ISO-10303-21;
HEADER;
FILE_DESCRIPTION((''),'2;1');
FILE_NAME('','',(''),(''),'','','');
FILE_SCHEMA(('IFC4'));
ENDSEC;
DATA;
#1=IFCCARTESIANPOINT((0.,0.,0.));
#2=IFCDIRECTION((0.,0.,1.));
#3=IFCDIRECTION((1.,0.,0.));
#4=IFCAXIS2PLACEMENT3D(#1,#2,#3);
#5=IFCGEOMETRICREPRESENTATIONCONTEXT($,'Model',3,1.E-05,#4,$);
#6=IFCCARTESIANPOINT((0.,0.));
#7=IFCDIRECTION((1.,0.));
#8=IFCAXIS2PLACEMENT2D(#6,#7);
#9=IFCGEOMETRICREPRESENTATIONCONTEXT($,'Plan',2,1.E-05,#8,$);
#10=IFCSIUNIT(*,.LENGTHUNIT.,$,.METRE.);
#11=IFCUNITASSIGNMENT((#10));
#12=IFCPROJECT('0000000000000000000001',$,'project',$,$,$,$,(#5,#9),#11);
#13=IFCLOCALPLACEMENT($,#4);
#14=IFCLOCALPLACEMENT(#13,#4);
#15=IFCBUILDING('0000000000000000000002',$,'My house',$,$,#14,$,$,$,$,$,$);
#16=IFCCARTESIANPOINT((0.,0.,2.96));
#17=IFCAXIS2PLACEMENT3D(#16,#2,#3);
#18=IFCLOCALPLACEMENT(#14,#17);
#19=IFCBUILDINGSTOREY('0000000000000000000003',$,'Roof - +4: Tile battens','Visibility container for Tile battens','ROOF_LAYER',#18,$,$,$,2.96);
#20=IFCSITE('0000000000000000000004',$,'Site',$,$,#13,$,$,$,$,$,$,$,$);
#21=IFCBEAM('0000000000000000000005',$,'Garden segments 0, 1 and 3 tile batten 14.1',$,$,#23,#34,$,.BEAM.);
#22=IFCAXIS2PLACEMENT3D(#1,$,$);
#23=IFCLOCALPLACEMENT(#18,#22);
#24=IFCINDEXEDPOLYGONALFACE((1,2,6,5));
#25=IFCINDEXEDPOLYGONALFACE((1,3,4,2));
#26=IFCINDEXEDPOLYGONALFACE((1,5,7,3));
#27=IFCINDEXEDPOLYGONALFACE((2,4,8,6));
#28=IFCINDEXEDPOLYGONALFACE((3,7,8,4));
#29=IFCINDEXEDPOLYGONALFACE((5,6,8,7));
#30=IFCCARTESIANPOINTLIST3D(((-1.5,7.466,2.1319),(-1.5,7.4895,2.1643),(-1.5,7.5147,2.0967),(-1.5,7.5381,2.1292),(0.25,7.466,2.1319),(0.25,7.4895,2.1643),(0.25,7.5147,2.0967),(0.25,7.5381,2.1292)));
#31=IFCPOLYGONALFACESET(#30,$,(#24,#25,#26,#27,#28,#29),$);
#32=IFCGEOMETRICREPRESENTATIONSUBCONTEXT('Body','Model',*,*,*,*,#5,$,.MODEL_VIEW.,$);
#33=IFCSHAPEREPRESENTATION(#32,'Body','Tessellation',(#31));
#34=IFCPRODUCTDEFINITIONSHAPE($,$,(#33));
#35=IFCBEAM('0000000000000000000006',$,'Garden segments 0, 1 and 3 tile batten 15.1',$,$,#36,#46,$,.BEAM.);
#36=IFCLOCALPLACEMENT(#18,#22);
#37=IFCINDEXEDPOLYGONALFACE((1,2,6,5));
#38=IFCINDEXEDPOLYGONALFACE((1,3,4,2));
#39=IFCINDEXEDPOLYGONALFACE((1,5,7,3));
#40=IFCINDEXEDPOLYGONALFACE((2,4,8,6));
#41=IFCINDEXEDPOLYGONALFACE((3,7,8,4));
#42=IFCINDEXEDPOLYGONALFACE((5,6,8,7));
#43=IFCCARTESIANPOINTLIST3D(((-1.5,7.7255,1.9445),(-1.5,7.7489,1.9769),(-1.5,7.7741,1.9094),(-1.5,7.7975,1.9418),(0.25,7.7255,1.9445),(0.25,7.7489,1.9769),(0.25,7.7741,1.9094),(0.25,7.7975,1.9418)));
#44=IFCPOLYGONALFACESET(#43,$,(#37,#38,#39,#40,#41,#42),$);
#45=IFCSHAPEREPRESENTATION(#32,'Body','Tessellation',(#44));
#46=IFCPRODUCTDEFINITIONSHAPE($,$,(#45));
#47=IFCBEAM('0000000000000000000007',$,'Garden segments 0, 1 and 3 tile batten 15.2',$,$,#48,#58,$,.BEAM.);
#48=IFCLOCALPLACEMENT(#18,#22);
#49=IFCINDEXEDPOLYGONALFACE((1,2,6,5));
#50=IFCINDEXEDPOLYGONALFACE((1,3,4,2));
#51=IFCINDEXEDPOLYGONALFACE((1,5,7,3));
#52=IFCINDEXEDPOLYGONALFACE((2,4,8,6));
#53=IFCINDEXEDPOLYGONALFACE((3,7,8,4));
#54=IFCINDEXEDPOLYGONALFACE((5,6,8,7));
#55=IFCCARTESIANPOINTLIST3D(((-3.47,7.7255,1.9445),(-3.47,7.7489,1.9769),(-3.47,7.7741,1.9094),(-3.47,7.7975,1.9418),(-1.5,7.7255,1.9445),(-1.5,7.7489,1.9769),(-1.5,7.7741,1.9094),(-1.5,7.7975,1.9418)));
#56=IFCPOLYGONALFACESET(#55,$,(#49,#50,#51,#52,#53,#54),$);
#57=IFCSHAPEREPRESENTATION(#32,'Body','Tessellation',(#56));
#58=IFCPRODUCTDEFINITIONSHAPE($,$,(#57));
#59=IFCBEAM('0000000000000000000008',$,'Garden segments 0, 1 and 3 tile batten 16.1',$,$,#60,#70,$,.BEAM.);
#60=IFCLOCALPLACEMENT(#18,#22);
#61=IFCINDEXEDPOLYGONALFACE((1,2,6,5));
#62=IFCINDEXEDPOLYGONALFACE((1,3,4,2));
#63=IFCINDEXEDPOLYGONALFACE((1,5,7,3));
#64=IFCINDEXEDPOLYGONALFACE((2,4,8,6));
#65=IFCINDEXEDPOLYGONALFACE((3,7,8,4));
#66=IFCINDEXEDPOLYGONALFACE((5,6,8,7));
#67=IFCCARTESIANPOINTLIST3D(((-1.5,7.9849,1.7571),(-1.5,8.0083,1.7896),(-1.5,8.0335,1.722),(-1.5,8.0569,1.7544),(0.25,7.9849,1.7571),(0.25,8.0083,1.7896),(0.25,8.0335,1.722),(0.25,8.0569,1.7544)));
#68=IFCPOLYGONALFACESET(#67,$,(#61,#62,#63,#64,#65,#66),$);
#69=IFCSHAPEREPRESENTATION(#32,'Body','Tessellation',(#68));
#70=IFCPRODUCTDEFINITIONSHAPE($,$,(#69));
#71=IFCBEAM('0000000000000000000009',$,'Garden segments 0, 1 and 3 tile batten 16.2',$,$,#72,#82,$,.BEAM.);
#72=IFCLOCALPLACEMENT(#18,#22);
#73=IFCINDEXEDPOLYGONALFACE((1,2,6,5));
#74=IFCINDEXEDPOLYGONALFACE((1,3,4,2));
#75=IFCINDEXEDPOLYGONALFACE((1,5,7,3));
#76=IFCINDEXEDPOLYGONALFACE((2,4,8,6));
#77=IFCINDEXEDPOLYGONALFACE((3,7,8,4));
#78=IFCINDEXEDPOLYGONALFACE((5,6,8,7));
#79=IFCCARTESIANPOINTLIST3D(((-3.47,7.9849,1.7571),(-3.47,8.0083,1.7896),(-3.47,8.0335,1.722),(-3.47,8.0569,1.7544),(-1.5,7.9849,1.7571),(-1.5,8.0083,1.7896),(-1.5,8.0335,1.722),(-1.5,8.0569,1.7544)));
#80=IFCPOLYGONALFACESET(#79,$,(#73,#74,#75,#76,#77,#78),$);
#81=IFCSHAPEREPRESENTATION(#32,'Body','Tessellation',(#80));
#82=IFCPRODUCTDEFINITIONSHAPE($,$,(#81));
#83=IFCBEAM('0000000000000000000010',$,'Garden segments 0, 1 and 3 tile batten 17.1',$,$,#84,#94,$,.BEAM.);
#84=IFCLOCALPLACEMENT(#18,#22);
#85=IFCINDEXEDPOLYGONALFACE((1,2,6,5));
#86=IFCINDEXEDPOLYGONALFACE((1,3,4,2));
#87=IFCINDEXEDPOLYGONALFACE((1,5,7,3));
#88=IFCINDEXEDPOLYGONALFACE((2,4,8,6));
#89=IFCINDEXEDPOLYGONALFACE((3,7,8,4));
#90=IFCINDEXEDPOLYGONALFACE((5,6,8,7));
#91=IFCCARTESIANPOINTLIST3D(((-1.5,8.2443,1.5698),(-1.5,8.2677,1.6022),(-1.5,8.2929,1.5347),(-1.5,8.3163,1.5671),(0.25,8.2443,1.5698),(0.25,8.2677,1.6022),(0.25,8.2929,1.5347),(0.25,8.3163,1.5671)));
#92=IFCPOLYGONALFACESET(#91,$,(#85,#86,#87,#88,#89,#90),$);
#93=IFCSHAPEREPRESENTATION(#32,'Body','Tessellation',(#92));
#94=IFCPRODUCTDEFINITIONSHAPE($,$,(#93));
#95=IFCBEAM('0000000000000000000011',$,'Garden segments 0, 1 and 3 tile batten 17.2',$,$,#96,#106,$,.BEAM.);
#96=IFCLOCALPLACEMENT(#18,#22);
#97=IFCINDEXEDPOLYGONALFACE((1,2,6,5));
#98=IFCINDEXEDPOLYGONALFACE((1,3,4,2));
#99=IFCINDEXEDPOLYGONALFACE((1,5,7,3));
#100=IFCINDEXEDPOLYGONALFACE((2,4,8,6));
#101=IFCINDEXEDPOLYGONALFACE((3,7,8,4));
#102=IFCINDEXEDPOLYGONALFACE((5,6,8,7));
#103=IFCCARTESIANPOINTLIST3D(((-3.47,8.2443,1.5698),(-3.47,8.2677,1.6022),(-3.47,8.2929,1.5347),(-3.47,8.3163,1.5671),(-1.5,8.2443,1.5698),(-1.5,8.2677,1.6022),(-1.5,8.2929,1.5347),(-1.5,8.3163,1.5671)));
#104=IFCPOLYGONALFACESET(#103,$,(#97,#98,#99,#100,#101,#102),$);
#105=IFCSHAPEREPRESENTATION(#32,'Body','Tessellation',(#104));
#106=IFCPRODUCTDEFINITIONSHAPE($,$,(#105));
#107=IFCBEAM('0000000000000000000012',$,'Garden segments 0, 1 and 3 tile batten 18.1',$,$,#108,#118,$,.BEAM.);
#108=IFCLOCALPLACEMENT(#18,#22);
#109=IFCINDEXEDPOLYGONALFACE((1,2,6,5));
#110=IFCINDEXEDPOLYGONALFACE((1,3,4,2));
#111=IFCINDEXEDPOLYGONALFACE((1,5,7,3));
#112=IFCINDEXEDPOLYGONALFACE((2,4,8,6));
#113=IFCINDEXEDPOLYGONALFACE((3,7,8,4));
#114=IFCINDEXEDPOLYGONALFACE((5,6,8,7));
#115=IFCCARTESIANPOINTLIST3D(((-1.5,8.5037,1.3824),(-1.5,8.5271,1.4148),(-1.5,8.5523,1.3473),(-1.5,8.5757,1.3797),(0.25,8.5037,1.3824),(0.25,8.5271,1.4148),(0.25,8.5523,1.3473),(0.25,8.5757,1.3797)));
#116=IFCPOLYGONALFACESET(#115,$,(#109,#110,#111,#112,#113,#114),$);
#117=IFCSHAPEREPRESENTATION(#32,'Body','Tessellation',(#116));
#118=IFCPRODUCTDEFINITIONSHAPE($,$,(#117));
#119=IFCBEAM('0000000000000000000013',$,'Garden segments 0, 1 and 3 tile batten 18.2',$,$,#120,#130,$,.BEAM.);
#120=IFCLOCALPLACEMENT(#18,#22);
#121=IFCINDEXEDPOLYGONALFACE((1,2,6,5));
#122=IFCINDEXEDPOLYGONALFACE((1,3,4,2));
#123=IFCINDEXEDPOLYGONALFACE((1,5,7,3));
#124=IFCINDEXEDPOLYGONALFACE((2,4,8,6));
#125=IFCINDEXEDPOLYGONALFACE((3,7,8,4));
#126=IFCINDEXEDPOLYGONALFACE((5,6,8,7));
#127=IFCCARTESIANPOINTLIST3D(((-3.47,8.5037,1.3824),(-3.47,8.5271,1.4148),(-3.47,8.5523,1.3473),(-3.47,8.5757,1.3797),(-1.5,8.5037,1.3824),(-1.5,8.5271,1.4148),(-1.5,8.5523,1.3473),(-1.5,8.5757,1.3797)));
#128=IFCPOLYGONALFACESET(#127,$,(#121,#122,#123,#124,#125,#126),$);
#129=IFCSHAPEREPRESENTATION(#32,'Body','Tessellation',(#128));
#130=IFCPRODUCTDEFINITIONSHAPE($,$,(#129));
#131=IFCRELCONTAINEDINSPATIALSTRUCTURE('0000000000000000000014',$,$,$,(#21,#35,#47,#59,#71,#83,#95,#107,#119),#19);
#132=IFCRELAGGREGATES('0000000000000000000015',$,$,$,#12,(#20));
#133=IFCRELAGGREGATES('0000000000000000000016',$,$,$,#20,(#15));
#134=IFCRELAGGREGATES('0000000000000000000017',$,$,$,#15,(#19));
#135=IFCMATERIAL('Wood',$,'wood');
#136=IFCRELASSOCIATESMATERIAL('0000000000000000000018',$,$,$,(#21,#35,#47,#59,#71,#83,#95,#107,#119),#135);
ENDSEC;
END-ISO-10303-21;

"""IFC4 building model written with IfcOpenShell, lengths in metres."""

from ifc_helpers import new_model, si_unit, frame, origin_with_axes, origin_2d_with_axis, place, context, subcontext, project, spatial, rectangle, extrude, clip, halfspace, source, transform, mapped, material, element, save


model = new_model("IFC4")

# Units and contexts
model_context = context("Model", 3, precision=1e-05, world=origin_with_axes())
plan_context = context("Plan", 2, precision=1e-05, world=origin_2d_with_axis())
body_context = subcontext(model_context, "Body", "Model", "MODEL_VIEW")
ifc_project = project(units=[si_unit("LENGTHUNIT", "METRE")], contexts=[model_context, plan_context])

# Site, building, storey
site_placement = place(None, origin_with_axes())
site = spatial("IfcSite", under=ifc_project, at=site_placement, Name="Site")
building_placement = place(site_placement, origin_with_axes())
building = spatial("IfcBuilding", under=site, at=building_placement, Name="My house")
storey_placement = place(building_placement, frame((0.0, 0.0, 2.96), z_axis=(0.0, 0.0, 1.0), x_axis=(1.0, 0.0, 0.0)))
storey = spatial("IfcBuildingStorey", under=building, at=storey_placement, Name="Roof - +4: Tile battens", Description="Visibility container for Tile battens", ObjectType="ROOF_LAYER", Elevation=2.96)

# Shared definitions
ifc_material = material(Name="Wood", Category="wood")

# Beam
shared_shape_1 = source(origin_with_axes(), body_context, "Body", "Clipping", [
    clip(clip(extrude(rectangle(XDim=0.06, YDim=0.04), frame((0.0, 0.0, 0.0), z_axis=(1.0, 0.0, 0.0), x_axis=(0.0, 1.0, 0.0)), (0.0, 0.0, 1.0), 1.75), halfspace(frame((0.25, 0.1416, -6.1772), z_axis=(0.0, -0.810664, -0.585512), x_axis=(-1.0, 0.0, 0.0)), False)), halfspace(frame((0.25, 3.9922, -3.396), z_axis=(0.0, 0.810664, 0.585512), x_axis=(1.0, 0.0, 0.0)), False)),
])
beam_1_placement = place(storey_placement, frame((0.25, 7.5021, 2.1305), z_axis=(0.0, 0.585512, 0.810664), x_axis=(1.0, 0.0, 0.0)))
element("IfcBeam", 1, at=beam_1_placement, inside=storey, material=ifc_material, Name="Garden segments 0, 1 and 3 tile batten 14.1", PredefinedType="BEAM", context=body_context, shape_type="MappedRepresentation", body=[
    mapped(shared_shape_1, transform((0.0, 0.0, 0.0), x_axis=(-1.0, 0.0, 0.0), y_axis=(0.0, 1.0, 0.0), z_axis=(0.0, 0.0, 1.0), scale=1.0)),
])

# Beams
shared_shape_2 = source(origin_with_axes(), body_context, "Body", "Clipping", [
    clip(clip(extrude(rectangle(XDim=0.06, YDim=0.04), frame((0.0, 0.0, 0.0), z_axis=(1.0, 0.0, 0.0), x_axis=(0.0, 1.0, 0.0)), (0.0, 0.0, 1.0), 1.75), halfspace(frame((0.25, -0.1784, -6.1772), z_axis=(0.0, -0.810664, -0.585512), x_axis=(-1.0, 0.0, 0.0)), False)), halfspace(frame((0.25, 3.6722, -3.396), z_axis=(0.0, 0.810664, 0.585512), x_axis=(1.0, 0.0, 0.0)), False)),
])
beam_2_placement = place(storey_placement, frame((0.25, 7.7615, 1.9432), z_axis=(0.0, 0.585512, 0.810664), x_axis=(1.0, 0.0, 0.0)))
element("IfcBeam", 2, at=beam_2_placement, inside=storey, material=ifc_material, Name="Garden segments 0, 1 and 3 tile batten 15.1", PredefinedType="BEAM", context=body_context, shape_type="MappedRepresentation", body=[
    mapped(shared_shape_2, transform((0.0, 0.0, 0.0), x_axis=(-1.0, 0.0, 0.0), y_axis=(0.0, 1.0, 0.0), z_axis=(0.0, 0.0, 1.0), scale=1.0)),
])
shared_shape_3 = source(origin_with_axes(), body_context, "Body", "Clipping", [
    clip(clip(extrude(rectangle(XDim=0.06, YDim=0.04), frame((0.0, 0.0, 0.0), z_axis=(1.0, 0.0, 0.0), x_axis=(0.0, 1.0, 0.0)), (0.0, 0.0, 1.0), 1.97), halfspace(frame((-1.5, -0.1784, -6.1772), z_axis=(0.0, -0.810664, -0.585512), x_axis=(-1.0, 0.0, 0.0)), False)), halfspace(frame((-1.5, 3.6722, -3.396), z_axis=(0.0, 0.810664, 0.585512), x_axis=(1.0, 0.0, 0.0)), False)),
])
beam_3_placement = place(storey_placement, frame((-1.5, 7.7615, 1.9432), z_axis=(0.0, 0.585512, 0.810664), x_axis=(1.0, 0.0, 0.0)))
element("IfcBeam", 3, at=beam_3_placement, inside=storey, material=ifc_material, Name="Garden segments 0, 1 and 3 tile batten 15.2", PredefinedType="BEAM", context=body_context, shape_type="MappedRepresentation", body=[
    mapped(shared_shape_3, transform((0.0, 0.0, 0.0), x_axis=(-1.0, 0.0, 0.0), y_axis=(0.0, 1.0, 0.0), z_axis=(0.0, 0.0, 1.0), scale=1.0)),
])
shared_shape_4 = source(origin_with_axes(), body_context, "Body", "Clipping", [
    clip(clip(extrude(rectangle(XDim=0.06, YDim=0.04), frame((0.0, 0.0, 0.0), z_axis=(1.0, 0.0, 0.0), x_axis=(0.0, 1.0, 0.0)), (0.0, 0.0, 1.0), 1.75), halfspace(frame((0.25, -0.4984, -6.1772), z_axis=(0.0, -0.810664, -0.585512), x_axis=(-1.0, 0.0, 0.0)), False)), halfspace(frame((0.25, 3.3522, -3.396), z_axis=(0.0, 0.810664, 0.585512), x_axis=(1.0, 0.0, 0.0)), False)),
])
beam_4_placement = place(storey_placement, frame((0.25, 8.0209, 1.7558), z_axis=(0.0, 0.585512, 0.810664), x_axis=(1.0, 0.0, 0.0)))
element("IfcBeam", 4, at=beam_4_placement, inside=storey, material=ifc_material, Name="Garden segments 0, 1 and 3 tile batten 16.1", PredefinedType="BEAM", context=body_context, shape_type="MappedRepresentation", body=[
    mapped(shared_shape_4, transform((0.0, 0.0, 0.0), x_axis=(-1.0, 0.0, 0.0), y_axis=(0.0, 1.0, 0.0), z_axis=(0.0, 0.0, 1.0), scale=1.0)),
])
shared_shape_5 = source(origin_with_axes(), body_context, "Body", "Clipping", [
    clip(clip(extrude(rectangle(XDim=0.06, YDim=0.04), frame((0.0, 0.0, 0.0), z_axis=(1.0, 0.0, 0.0), x_axis=(0.0, 1.0, 0.0)), (0.0, 0.0, 1.0), 1.97), halfspace(frame((-1.5, -0.4984, -6.1772), z_axis=(0.0, -0.810664, -0.585512), x_axis=(-1.0, 0.0, 0.0)), False)), halfspace(frame((-1.5, 3.3522, -3.396), z_axis=(0.0, 0.810664, 0.585512), x_axis=(1.0, 0.0, 0.0)), False)),
])
beam_5_placement = place(storey_placement, frame((-1.5, 8.0209, 1.7558), z_axis=(0.0, 0.585512, 0.810664), x_axis=(1.0, 0.0, 0.0)))
element("IfcBeam", 5, at=beam_5_placement, inside=storey, material=ifc_material, Name="Garden segments 0, 1 and 3 tile batten 16.2", PredefinedType="BEAM", context=body_context, shape_type="MappedRepresentation", body=[
    mapped(shared_shape_5, transform((0.0, 0.0, 0.0), x_axis=(-1.0, 0.0, 0.0), y_axis=(0.0, 1.0, 0.0), z_axis=(0.0, 0.0, 1.0), scale=1.0)),
])
shared_shape_6 = source(origin_with_axes(), body_context, "Body", "Clipping", [
    clip(clip(extrude(rectangle(XDim=0.06, YDim=0.04), frame((0.0, 0.0, 0.0), z_axis=(1.0, 0.0, 0.0), x_axis=(0.0, 1.0, 0.0)), (0.0, 0.0, 1.0), 1.75), halfspace(frame((0.25, -0.8184, -6.1772), z_axis=(0.0, -0.810664, -0.585512), x_axis=(-1.0, 0.0, 0.0)), False)), halfspace(frame((0.25, 3.0322, -3.396), z_axis=(0.0, 0.810664, 0.585512), x_axis=(1.0, 0.0, 0.0)), False)),
])
beam_6_placement = place(storey_placement, frame((0.25, 8.2803, 1.5684), z_axis=(0.0, 0.585512, 0.810664), x_axis=(1.0, 0.0, 0.0)))
element("IfcBeam", 6, at=beam_6_placement, inside=storey, material=ifc_material, Name="Garden segments 0, 1 and 3 tile batten 17.1", PredefinedType="BEAM", context=body_context, shape_type="MappedRepresentation", body=[
    mapped(shared_shape_6, transform((0.0, 0.0, 0.0), x_axis=(-1.0, 0.0, 0.0), y_axis=(0.0, 1.0, 0.0), z_axis=(0.0, 0.0, 1.0), scale=1.0)),
])
shared_shape_7 = source(origin_with_axes(), body_context, "Body", "Clipping", [
    clip(clip(extrude(rectangle(XDim=0.06, YDim=0.04), frame((0.0, 0.0, 0.0), z_axis=(1.0, 0.0, 0.0), x_axis=(0.0, 1.0, 0.0)), (0.0, 0.0, 1.0), 1.97), halfspace(frame((-1.5, -0.8184, -6.1772), z_axis=(0.0, -0.810664, -0.585512), x_axis=(-1.0, 0.0, 0.0)), False)), halfspace(frame((-1.5, 3.0322, -3.396), z_axis=(0.0, 0.810664, 0.585512), x_axis=(1.0, 0.0, 0.0)), False)),
])
beam_7_placement = place(storey_placement, frame((-1.5, 8.2803, 1.5684), z_axis=(0.0, 0.585512, 0.810664), x_axis=(1.0, 0.0, 0.0)))
element("IfcBeam", 7, at=beam_7_placement, inside=storey, material=ifc_material, Name="Garden segments 0, 1 and 3 tile batten 17.2", PredefinedType="BEAM", context=body_context, shape_type="MappedRepresentation", body=[
    mapped(shared_shape_7, transform((0.0, 0.0, 0.0), x_axis=(-1.0, 0.0, 0.0), y_axis=(0.0, 1.0, 0.0), z_axis=(0.0, 0.0, 1.0), scale=1.0)),
])
shared_shape_8 = source(origin_with_axes(), body_context, "Body", "Clipping", [
    clip(clip(extrude(rectangle(XDim=0.06, YDim=0.04), frame((0.0, 0.0, 0.0), z_axis=(1.0, 0.0, 0.0), x_axis=(0.0, 1.0, 0.0)), (0.0, 0.0, 1.0), 1.75), halfspace(frame((0.25, -1.1384, -6.1772), z_axis=(0.0, -0.810664, -0.585512), x_axis=(-1.0, 0.0, 0.0)), False)), halfspace(frame((0.25, 2.7122, -3.396), z_axis=(0.0, 0.810664, 0.585512), x_axis=(1.0, 0.0, 0.0)), False)),
])
beam_8_placement = place(storey_placement, frame((0.25, 8.5397, 1.3811), z_axis=(0.0, 0.585512, 0.810664), x_axis=(1.0, 0.0, 0.0)))
element("IfcBeam", 8, at=beam_8_placement, inside=storey, material=ifc_material, Name="Garden segments 0, 1 and 3 tile batten 18.1", PredefinedType="BEAM", context=body_context, shape_type="MappedRepresentation", body=[
    mapped(shared_shape_8, transform((0.0, 0.0, 0.0), x_axis=(-1.0, 0.0, 0.0), y_axis=(0.0, 1.0, 0.0), z_axis=(0.0, 0.0, 1.0), scale=1.0)),
])
shared_shape_9 = source(origin_with_axes(), body_context, "Body", "Clipping", [
    clip(clip(extrude(rectangle(XDim=0.06, YDim=0.04), frame((0.0, 0.0, 0.0), z_axis=(1.0, 0.0, 0.0), x_axis=(0.0, 1.0, 0.0)), (0.0, 0.0, 1.0), 1.97), halfspace(frame((-1.5, -1.1384, -6.1772), z_axis=(0.0, -0.810664, -0.585512), x_axis=(-1.0, 0.0, 0.0)), False)), halfspace(frame((-1.5, 2.7122, -3.396), z_axis=(0.0, 0.810664, 0.585512), x_axis=(1.0, 0.0, 0.0)), False)),
])
beam_9_placement = place(storey_placement, frame((-1.5, 8.5397, 1.3811), z_axis=(0.0, 0.585512, 0.810664), x_axis=(1.0, 0.0, 0.0)))
element("IfcBeam", 9, at=beam_9_placement, inside=storey, material=ifc_material, Name="Garden segments 0, 1 and 3 tile batten 18.2", PredefinedType="BEAM", context=body_context, shape_type="MappedRepresentation", body=[
    mapped(shared_shape_9, transform((0.0, 0.0, 0.0), x_axis=(-1.0, 0.0, 0.0), y_axis=(0.0, 1.0, 0.0), z_axis=(0.0, 0.0, 1.0), scale=1.0)),
])

save(model, "model.ifc")
